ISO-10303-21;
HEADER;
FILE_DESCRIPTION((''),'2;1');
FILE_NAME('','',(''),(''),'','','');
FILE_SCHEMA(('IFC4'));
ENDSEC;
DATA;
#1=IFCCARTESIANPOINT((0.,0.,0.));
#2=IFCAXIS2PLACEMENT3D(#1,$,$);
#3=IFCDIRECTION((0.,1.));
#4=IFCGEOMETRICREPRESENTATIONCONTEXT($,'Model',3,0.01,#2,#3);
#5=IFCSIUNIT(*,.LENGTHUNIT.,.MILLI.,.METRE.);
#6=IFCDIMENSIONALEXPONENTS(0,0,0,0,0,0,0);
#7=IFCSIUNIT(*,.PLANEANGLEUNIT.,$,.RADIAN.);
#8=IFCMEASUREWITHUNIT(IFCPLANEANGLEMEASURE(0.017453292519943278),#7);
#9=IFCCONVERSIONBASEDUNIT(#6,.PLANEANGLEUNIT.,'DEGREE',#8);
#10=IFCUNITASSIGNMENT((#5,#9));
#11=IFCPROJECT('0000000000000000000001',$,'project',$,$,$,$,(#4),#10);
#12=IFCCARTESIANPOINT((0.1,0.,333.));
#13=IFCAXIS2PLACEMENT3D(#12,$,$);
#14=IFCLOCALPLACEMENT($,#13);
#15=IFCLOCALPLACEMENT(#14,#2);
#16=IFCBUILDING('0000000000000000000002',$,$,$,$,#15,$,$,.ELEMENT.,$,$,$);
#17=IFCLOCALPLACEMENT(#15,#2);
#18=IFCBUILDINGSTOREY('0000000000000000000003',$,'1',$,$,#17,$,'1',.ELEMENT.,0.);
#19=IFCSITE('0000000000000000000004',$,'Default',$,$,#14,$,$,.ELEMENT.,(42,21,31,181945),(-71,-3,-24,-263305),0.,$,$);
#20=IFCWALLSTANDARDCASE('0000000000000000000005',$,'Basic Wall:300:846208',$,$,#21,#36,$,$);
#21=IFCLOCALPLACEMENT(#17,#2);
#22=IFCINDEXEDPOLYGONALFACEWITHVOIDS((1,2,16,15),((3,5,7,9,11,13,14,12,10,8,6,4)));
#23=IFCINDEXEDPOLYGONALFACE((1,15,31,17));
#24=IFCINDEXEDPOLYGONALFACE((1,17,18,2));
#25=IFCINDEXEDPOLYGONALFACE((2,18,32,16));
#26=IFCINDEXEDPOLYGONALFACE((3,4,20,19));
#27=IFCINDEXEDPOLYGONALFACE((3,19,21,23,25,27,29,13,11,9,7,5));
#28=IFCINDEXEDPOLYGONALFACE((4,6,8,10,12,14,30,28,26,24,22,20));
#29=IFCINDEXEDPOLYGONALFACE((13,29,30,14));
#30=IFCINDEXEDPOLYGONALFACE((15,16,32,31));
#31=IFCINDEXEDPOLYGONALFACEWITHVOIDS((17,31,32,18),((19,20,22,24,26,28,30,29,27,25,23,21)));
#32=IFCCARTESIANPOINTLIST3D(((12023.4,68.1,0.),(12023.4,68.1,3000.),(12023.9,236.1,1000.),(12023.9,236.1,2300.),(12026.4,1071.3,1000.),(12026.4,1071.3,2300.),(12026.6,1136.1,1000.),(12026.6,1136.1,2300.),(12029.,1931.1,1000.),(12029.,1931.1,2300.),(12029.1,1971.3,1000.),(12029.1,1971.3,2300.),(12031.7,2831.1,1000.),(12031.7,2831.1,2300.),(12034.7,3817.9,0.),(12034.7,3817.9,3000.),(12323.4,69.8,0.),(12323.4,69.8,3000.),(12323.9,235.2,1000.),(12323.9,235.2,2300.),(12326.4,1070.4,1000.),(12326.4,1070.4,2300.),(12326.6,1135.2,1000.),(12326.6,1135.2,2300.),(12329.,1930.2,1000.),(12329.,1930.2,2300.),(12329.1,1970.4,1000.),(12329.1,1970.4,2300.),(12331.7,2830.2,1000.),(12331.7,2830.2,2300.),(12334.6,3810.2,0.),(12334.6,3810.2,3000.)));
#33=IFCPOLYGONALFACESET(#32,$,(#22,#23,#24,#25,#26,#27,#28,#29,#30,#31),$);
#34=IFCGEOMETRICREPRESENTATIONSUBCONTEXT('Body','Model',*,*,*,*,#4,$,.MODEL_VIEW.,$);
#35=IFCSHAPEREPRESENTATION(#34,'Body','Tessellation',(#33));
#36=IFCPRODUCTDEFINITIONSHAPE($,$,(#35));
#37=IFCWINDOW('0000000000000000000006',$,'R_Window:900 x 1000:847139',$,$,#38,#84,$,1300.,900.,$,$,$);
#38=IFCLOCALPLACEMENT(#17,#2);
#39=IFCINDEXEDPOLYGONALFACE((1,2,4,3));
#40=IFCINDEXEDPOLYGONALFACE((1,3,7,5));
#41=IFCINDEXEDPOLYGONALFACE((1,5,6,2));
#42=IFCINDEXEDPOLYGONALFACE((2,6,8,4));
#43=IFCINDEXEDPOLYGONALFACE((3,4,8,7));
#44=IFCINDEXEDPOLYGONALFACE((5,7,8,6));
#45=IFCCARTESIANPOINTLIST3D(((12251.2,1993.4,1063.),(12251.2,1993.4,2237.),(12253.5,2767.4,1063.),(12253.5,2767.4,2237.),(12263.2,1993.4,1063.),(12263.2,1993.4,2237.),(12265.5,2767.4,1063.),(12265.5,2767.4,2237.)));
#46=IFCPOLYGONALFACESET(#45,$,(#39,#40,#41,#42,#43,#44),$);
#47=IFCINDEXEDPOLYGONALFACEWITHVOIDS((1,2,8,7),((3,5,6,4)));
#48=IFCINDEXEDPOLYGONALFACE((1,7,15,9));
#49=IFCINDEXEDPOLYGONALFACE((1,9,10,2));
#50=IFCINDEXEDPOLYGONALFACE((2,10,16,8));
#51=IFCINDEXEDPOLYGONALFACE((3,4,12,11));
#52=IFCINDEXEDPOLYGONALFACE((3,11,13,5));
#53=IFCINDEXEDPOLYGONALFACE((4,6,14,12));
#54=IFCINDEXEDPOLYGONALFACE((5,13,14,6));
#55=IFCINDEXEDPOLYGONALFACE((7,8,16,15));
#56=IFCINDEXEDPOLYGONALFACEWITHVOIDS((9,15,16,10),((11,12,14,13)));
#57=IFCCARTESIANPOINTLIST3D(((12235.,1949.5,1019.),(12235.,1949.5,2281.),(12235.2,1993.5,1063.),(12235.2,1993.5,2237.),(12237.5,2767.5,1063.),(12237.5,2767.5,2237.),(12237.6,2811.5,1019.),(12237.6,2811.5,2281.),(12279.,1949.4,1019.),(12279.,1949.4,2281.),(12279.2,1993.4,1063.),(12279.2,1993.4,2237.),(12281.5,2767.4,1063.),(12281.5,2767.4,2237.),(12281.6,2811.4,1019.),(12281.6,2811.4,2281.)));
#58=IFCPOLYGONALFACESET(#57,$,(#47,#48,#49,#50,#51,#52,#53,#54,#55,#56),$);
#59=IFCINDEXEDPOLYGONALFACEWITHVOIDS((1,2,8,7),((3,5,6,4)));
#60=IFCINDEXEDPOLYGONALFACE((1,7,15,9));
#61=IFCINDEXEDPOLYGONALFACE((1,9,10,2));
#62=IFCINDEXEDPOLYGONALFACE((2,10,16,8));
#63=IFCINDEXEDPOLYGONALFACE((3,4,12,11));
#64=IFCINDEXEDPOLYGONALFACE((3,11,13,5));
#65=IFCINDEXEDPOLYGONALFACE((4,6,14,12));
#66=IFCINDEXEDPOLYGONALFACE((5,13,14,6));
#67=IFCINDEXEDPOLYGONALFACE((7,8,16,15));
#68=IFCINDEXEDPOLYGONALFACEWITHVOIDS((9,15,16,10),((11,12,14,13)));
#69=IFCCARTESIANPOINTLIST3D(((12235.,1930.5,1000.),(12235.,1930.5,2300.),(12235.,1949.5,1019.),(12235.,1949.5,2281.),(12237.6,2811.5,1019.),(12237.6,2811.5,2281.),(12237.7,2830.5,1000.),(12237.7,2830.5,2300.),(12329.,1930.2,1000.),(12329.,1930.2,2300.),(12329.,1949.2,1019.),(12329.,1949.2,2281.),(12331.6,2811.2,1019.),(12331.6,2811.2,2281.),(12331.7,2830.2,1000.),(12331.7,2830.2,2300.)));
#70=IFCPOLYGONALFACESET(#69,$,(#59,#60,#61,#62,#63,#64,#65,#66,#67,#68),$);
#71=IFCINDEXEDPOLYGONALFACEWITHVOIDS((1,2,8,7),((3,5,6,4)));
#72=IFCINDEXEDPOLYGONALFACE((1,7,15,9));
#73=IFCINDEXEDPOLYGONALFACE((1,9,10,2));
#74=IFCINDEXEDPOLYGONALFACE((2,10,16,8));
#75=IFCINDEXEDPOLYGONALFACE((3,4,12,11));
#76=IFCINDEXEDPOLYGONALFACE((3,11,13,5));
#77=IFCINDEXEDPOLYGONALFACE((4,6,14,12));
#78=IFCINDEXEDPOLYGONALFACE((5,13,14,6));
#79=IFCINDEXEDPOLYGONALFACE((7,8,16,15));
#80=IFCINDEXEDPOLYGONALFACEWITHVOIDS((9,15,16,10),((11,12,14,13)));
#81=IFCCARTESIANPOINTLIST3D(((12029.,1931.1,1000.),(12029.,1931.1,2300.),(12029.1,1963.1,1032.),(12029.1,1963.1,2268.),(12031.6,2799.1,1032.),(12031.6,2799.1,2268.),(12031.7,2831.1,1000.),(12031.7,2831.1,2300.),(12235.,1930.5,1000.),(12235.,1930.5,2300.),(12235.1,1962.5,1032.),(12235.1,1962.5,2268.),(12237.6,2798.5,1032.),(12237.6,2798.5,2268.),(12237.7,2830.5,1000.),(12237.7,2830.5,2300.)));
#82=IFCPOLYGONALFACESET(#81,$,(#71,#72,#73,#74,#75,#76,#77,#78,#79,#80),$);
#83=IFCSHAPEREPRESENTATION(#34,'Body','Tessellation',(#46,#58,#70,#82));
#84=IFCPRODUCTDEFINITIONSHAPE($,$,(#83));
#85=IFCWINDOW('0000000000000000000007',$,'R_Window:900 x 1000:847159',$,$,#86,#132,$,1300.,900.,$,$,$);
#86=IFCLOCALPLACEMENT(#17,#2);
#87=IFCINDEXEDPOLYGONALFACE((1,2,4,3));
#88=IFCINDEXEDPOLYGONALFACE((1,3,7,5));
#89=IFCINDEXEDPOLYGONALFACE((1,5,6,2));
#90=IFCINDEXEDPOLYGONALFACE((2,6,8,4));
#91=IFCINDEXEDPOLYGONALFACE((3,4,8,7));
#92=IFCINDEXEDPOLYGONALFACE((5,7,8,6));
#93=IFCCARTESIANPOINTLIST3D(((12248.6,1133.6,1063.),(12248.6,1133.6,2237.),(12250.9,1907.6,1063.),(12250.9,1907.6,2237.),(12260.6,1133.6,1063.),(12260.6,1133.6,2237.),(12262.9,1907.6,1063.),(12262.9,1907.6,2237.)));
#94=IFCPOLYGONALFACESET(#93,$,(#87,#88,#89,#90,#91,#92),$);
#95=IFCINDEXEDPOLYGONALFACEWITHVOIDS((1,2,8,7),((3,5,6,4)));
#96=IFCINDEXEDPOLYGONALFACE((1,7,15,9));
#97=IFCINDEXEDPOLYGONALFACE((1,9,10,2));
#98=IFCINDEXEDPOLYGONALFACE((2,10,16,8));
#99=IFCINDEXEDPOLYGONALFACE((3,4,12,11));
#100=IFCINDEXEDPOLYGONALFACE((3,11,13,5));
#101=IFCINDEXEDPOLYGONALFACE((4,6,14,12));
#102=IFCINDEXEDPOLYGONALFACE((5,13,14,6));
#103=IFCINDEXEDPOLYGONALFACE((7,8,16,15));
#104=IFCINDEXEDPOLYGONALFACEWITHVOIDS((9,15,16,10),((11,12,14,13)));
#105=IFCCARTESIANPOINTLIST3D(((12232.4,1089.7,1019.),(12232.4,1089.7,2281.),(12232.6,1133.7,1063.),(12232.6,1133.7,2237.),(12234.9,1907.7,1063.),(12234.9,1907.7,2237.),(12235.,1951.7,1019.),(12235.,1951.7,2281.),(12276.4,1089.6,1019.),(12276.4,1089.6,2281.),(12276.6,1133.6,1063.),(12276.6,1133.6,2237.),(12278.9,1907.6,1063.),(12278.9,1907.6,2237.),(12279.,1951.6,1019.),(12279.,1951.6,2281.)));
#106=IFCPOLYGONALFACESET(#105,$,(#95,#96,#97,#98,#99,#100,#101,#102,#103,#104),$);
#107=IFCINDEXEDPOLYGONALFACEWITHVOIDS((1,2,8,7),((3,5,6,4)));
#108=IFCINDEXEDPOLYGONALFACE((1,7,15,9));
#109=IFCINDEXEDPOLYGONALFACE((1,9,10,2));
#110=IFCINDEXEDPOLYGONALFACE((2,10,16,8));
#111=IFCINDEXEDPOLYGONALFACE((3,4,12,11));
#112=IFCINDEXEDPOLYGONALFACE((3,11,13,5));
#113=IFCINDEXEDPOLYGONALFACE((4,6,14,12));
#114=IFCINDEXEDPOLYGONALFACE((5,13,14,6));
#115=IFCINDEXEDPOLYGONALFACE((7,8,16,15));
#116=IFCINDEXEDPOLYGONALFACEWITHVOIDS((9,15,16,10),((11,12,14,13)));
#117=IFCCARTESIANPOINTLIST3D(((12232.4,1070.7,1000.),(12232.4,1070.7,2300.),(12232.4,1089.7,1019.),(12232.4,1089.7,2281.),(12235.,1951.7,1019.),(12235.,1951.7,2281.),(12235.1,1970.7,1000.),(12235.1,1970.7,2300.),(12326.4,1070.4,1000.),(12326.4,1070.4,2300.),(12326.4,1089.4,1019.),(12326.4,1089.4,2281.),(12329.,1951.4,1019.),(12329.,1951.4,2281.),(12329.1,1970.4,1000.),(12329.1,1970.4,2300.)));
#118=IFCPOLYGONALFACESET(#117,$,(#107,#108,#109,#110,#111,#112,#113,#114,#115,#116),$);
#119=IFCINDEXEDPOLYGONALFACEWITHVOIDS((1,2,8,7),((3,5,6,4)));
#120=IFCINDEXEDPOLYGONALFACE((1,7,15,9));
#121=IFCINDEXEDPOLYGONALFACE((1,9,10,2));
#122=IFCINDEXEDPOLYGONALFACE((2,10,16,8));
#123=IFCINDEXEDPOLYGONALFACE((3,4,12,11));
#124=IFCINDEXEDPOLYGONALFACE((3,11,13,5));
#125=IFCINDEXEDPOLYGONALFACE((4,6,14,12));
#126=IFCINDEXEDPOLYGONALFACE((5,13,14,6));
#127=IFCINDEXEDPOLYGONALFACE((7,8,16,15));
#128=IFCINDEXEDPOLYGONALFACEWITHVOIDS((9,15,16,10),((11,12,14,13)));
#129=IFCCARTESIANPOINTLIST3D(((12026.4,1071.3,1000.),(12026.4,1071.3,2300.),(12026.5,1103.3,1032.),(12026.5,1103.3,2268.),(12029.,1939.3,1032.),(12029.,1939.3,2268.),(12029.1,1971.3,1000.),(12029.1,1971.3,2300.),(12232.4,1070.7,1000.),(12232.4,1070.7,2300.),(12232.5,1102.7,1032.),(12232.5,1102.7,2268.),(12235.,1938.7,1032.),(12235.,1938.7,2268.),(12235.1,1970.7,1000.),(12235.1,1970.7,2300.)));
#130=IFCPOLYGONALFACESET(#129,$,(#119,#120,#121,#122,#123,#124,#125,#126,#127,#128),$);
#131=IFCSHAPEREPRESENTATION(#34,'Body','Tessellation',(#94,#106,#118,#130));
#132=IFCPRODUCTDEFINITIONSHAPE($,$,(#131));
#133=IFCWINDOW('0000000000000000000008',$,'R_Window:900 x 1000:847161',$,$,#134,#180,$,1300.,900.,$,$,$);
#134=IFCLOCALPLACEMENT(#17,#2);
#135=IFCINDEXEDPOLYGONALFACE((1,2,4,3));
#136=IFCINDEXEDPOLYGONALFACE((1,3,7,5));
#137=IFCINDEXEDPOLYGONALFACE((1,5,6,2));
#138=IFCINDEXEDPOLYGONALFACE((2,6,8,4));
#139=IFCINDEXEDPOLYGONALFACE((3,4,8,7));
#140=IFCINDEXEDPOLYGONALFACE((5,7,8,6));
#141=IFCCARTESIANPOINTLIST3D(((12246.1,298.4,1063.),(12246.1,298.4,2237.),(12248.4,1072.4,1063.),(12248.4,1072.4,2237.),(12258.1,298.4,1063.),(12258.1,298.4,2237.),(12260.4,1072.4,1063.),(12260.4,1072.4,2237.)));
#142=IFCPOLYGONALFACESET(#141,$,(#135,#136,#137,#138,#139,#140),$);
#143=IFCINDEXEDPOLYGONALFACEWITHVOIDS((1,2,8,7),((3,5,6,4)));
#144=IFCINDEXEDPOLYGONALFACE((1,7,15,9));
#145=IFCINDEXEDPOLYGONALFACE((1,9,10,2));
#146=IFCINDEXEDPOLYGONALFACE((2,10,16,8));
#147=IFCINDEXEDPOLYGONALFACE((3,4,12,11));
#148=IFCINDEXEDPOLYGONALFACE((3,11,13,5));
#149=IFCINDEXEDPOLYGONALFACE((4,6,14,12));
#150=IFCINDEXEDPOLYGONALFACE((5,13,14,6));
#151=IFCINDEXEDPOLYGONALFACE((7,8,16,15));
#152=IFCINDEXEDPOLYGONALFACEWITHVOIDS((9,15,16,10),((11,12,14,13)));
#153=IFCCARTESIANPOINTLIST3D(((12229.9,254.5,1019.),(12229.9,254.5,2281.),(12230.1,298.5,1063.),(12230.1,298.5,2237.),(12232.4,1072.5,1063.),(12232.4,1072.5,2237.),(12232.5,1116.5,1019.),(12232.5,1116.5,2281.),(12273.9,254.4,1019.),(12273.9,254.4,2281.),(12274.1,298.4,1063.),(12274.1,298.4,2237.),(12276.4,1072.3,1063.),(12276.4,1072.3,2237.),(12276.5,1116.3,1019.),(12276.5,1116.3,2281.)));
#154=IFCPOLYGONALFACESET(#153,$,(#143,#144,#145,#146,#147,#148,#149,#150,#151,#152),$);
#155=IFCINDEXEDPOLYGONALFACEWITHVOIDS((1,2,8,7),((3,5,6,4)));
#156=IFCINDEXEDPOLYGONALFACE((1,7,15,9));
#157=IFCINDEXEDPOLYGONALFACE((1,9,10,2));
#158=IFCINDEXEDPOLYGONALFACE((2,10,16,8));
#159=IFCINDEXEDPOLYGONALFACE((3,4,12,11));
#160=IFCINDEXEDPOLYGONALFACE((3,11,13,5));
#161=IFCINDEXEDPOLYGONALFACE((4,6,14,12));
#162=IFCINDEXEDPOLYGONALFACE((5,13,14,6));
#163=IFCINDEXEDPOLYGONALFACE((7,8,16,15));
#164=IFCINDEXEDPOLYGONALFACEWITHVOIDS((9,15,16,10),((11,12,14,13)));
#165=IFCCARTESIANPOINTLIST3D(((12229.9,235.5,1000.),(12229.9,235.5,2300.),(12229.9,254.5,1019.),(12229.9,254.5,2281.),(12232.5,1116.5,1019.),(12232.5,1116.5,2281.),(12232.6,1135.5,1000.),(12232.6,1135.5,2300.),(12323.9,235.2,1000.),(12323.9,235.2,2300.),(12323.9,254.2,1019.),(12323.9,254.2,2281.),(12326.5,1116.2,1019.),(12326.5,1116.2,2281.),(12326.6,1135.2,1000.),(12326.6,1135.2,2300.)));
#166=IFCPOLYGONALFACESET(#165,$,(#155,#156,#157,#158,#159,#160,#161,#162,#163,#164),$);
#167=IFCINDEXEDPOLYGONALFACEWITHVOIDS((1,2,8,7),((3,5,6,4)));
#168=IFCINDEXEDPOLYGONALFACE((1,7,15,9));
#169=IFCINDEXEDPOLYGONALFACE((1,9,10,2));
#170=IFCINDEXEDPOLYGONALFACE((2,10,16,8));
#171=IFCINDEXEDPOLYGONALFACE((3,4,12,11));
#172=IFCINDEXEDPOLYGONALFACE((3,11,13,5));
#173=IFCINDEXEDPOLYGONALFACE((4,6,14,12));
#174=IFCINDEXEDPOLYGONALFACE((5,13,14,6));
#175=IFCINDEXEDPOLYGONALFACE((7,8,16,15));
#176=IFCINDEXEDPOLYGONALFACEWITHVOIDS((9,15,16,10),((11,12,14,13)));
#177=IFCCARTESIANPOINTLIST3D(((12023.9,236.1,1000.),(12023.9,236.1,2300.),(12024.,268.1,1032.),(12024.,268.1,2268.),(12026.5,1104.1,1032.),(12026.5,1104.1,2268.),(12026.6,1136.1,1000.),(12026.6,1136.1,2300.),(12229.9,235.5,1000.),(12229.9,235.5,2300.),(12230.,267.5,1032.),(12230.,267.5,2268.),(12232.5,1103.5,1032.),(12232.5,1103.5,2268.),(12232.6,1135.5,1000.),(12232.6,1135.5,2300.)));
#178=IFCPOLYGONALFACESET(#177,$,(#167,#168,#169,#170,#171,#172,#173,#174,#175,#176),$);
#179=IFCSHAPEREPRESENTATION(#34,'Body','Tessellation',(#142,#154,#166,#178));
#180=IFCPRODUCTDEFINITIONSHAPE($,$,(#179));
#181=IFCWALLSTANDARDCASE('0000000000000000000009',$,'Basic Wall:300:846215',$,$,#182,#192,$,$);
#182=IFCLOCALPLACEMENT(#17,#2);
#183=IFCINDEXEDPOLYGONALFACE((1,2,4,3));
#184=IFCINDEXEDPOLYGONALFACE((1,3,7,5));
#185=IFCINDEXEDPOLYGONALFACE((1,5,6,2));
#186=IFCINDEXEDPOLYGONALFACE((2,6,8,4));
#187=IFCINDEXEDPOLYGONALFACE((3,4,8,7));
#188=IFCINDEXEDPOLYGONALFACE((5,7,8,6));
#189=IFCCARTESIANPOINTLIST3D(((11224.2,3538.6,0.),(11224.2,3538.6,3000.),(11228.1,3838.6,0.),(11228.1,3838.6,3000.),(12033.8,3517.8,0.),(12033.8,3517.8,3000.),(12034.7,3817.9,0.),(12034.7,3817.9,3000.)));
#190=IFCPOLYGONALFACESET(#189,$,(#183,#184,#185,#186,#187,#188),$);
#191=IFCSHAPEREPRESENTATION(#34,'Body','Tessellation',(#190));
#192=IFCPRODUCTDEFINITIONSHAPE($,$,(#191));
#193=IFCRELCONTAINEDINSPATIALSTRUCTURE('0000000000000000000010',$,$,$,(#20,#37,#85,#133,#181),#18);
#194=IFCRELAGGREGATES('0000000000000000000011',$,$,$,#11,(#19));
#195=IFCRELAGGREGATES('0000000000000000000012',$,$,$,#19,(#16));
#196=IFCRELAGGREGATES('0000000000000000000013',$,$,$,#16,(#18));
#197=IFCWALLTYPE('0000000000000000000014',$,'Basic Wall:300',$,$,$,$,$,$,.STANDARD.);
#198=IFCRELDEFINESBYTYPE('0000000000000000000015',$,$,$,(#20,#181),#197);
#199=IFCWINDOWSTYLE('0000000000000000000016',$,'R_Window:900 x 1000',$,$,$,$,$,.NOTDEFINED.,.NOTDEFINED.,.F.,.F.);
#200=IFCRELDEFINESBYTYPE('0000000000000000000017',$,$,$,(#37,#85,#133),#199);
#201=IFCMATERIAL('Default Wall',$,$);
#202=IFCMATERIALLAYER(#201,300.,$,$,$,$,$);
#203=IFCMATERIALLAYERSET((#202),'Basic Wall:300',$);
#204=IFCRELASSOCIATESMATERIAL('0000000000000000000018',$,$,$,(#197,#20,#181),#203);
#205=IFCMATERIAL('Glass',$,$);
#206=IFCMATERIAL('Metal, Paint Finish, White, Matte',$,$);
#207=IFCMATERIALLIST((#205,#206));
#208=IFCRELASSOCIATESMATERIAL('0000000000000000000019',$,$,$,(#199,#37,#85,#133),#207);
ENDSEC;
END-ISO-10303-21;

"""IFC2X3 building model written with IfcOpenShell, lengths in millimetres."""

from ifc_helpers import new_model, entity, si_unit, converted_unit, direction, frame, frame_2d, origin, place, context, subcontext, project, spatial, polyline, rectangle, outline, extrude, source, transform, mapped, material, material_list, layer, layer_set, layer_usage, type_object, type_shapes, element, fill, save


model = new_model("IFC2X3")

# Units and contexts
model_context = context("Model", 3, precision=0.01, world=origin(), true_north=direction((0.0, 1.0)))
body_context = subcontext(model_context, "Body", "Model", "MODEL_VIEW")
ifc_project = project(units=[si_unit("LENGTHUNIT", "METRE", prefix="MILLI"), converted_unit("PLANEANGLEUNIT", "DEGREE", entity("IfcPlaneAngleMeasure", 0.017453292519943278), si_unit("PLANEANGLEUNIT", "RADIAN"), dimensions=[0, 0, 0, 0, 0, 0, 0])], contexts=[model_context])

# Site, building, storey
site_placement = place(None, frame((0.1, 0.0, 333.0)))
site = spatial("IfcSite", under=ifc_project, at=site_placement, Name="Default", CompositionType="ELEMENT", RefLatitude=(42, 21, 31, 181945), RefLongitude=(-71, -3, -24, -263305), RefElevation=0.0)
building_placement = place(site_placement, origin())
building = spatial("IfcBuilding", under=site, at=building_placement, CompositionType="ELEMENT")
storey_placement = place(building_placement, origin())
storey = spatial("IfcBuildingStorey", under=building, at=storey_placement, Name="1", LongName="1", CompositionType="ELEMENT", Elevation=0.0)

# Shared definitions
ifc_material_1 = material(Name="Default Wall")
ifc_layer_1 = layer(ifc_material_1, 300.0)
ifc_layer_set_1 = layer_set([ifc_layer_1], Name="Basic Wall:300")
wall_type_1 = type_object("IfcWallType", Name="Basic Wall:300", PredefinedType="STANDARD", material=ifc_layer_set_1)

# Wall, openings, windows
ifc_layer_usage_1 = layer_usage(ifc_layer_set_1, "AXIS2", "NEGATIVE", 150.0)
wall_1_placement = place(storey_placement, frame((12184.7, 3817.4, 0.0), z_axis=(0.0, 0.0, 1.0), x_axis=(-0.003012, -0.999995, 0.0)))
wall_1 = element("IfcWallStandardCase", 1, at=wall_1_placement, inside=storey, type_object=wall_type_1, material=ifc_layer_usage_1, Name="Basic Wall:300:846208", context=body_context, shape_type="SweptSolid", body=[
    extrude(outline(polyline([(3749.8, -150.0), (3747.2, 150.0), (6.8, 150.0), (0.0, -150.0), (300.1, -150.0), (3749.8, -150.0)])), origin(), (0.0, 0.0, 1.0), 3000.0),
])
opening_1_placement = place(wall_1_placement, frame((986.8, -150.0, 1000.0)))
opening_1 = element("IfcOpeningElement", 2, at=opening_1_placement, cuts=wall_1, ObjectType="Opening", context=body_context, shape_type="SweptSolid", body=[
    extrude(rectangle(XDim=1300.0, YDim=900.0, at=frame_2d((650.0, 450.0), x_axis=(1.0, 0.0))), frame((0.0, 0.0, 0.0), z_axis=(0.0, 1.0, 0.0), x_axis=(0.0, 0.0, 1.0)), (0.0, 0.0, 1.0), 300.0),
])
opening_2_placement = place(wall_1_placement, frame((1846.6, -150.0, 1000.0)))
opening_2 = element("IfcOpeningElement", 3, at=opening_2_placement, cuts=wall_1, ObjectType="Opening", context=body_context, shape_type="SweptSolid", body=[
    extrude(rectangle(XDim=1300.0, YDim=900.0, at=frame_2d((650.0, 450.0), x_axis=(1.0, 0.0))), frame((0.0, 0.0, 0.0), z_axis=(0.0, 1.0, 0.0), x_axis=(0.0, 0.0, 1.0)), (0.0, 0.0, 1.0), 300.0),
])
opening_3_placement = place(wall_1_placement, frame((2681.8, -150.0, 1000.0)))
opening_3 = element("IfcOpeningElement", 4, at=opening_3_placement, cuts=wall_1, ObjectType="Opening", context=body_context, shape_type="SweptSolid", body=[
    extrude(rectangle(XDim=1300.0, YDim=900.0, at=frame_2d((650.0, 450.0), x_axis=(1.0, 0.0))), frame((0.0, 0.0, 0.0), z_axis=(0.0, 1.0, 0.0), x_axis=(0.0, 0.0, 1.0)), (0.0, 0.0, 1.0), 300.0),
])
ifc_material_2 = material(Name="Glass")
ifc_material_3 = material(Name="Metal, Paint Finish, White, Matte")
ifc_material_list_1 = material_list([ifc_material_2, ifc_material_3])
window_style = type_object("IfcWindowStyle", Name="R_Window:900 x 1000", ConstructionType="NOTDEFINED", OperationType="NOTDEFINED", ParameterTakesPrecedence=False, Sizeable=False, material=ifc_material_list_1)
shared_shape_1 = source(origin(), body_context, "Body", "SweptSolid", [
    extrude(rectangle(XDim=12.0, YDim=774.0, at=frame_2d((0.0, 0.0), x_axis=(1.0, 0.0))), frame((450.0, 228.0, 63.0), z_axis=(0.0, 0.0, 1.0), x_axis=(0.0, -1.0, 0.0)), (0.0, 0.0, 1.0), 1174.0),
    extrude(outline(polyline([(-431.0, -631.0), (431.0, -631.0), (431.0, 631.0), (-431.0, 631.0), (-431.0, -631.0)]), holes=[polyline([(-387.0, -587.0), (-387.0, 587.0), (387.0, 587.0), (387.0, -587.0), (-387.0, -587.0)])]), frame((450.0, 206.0, 650.0), z_axis=(0.0, 1.0, 0.0), x_axis=(1.0, 0.0, 0.0)), (0.0, 0.0, 1.0), 44.0),
    extrude(outline(polyline([(-450.0, -650.0), (450.0, -650.0), (450.0, 650.0), (-450.0, 650.0), (-450.0, -650.0)]), holes=[polyline([(-431.0, -631.0), (-431.0, 631.0), (431.0, 631.0), (431.0, -631.0), (-431.0, -631.0)])]), frame((450.0, 206.0, 650.0), z_axis=(0.0, 1.0, 0.0), x_axis=(1.0, 0.0, 0.0)), (0.0, 0.0, 1.0), 94.0),
    extrude(outline(polyline([(-450.0, -650.0), (450.0, -650.0), (450.0, 650.0), (-450.0, 650.0), (-450.0, -650.0)]), holes=[polyline([(-418.0, -618.0), (-418.0, 618.0), (418.0, 618.0), (418.0, -618.0), (-418.0, -618.0)])]), frame((450.0, 0.0, 650.0), z_axis=(0.0, 1.0, 0.0), x_axis=(1.0, 0.0, 0.0)), (0.0, 0.0, 1.0), 206.0),
])
type_shapes(window_style, [shared_shape_1])
window_1_placement = place(opening_1_placement, origin())
window_1 = element("IfcWindow", 5, at=window_1_placement, inside=storey, type_object=window_style, material=ifc_material_list_1, Name="R_Window:900 x 1000:847139", OverallHeight=1300.0, OverallWidth=900.0, context=body_context, shape_type="MappedRepresentation", body=[
    mapped(shared_shape_1, transform((0.0, 0.0, 0.0), scale=1.0)),
])
fill(opening_1, window_1)
window_2_placement = place(opening_2_placement, origin())
window_2 = element("IfcWindow", 6, at=window_2_placement, inside=storey, type_object=window_style, material=ifc_material_list_1, Name="R_Window:900 x 1000:847159", OverallHeight=1300.0, OverallWidth=900.0, context=body_context, shape_type="MappedRepresentation", body=[
    mapped(shared_shape_1, transform((0.0, 0.0, 0.0), scale=1.0)),
])
fill(opening_2, window_2)
window_3_placement = place(opening_3_placement, origin())
window_3 = element("IfcWindow", 7, at=window_3_placement, inside=storey, type_object=window_style, material=ifc_material_list_1, Name="R_Window:900 x 1000:847161", OverallHeight=1300.0, OverallWidth=900.0, context=body_context, shape_type="MappedRepresentation", body=[
    mapped(shared_shape_1, transform((0.0, 0.0, 0.0), scale=1.0)),
])
fill(opening_3, window_3)

# Wall
ifc_layer_usage_2 = layer_usage(ifc_layer_set_1, "AXIS2", "NEGATIVE", 150.0)
wall_2_placement = place(storey_placement, frame((11224.2, 3688.7, 0.0), z_axis=(0.0, 0.0, 1.0), x_axis=(0.99967, -0.025697, 0.0)))
element("IfcWallStandardCase", 8, at=wall_2_placement, inside=storey, type_object=wall_type_1, material=ifc_layer_usage_2, Name="Basic Wall:300:846215", context=body_context, shape_type="SweptSolid", body=[
    extrude(outline(polyline([(813.6, -150.0), (806.8, 150.0), (0.0, 150.0), (3.9, -150.0), (813.6, -150.0)])), origin(), (0.0, 0.0, 1.0), 3000.0),
])

save(model, "model.ifc")
